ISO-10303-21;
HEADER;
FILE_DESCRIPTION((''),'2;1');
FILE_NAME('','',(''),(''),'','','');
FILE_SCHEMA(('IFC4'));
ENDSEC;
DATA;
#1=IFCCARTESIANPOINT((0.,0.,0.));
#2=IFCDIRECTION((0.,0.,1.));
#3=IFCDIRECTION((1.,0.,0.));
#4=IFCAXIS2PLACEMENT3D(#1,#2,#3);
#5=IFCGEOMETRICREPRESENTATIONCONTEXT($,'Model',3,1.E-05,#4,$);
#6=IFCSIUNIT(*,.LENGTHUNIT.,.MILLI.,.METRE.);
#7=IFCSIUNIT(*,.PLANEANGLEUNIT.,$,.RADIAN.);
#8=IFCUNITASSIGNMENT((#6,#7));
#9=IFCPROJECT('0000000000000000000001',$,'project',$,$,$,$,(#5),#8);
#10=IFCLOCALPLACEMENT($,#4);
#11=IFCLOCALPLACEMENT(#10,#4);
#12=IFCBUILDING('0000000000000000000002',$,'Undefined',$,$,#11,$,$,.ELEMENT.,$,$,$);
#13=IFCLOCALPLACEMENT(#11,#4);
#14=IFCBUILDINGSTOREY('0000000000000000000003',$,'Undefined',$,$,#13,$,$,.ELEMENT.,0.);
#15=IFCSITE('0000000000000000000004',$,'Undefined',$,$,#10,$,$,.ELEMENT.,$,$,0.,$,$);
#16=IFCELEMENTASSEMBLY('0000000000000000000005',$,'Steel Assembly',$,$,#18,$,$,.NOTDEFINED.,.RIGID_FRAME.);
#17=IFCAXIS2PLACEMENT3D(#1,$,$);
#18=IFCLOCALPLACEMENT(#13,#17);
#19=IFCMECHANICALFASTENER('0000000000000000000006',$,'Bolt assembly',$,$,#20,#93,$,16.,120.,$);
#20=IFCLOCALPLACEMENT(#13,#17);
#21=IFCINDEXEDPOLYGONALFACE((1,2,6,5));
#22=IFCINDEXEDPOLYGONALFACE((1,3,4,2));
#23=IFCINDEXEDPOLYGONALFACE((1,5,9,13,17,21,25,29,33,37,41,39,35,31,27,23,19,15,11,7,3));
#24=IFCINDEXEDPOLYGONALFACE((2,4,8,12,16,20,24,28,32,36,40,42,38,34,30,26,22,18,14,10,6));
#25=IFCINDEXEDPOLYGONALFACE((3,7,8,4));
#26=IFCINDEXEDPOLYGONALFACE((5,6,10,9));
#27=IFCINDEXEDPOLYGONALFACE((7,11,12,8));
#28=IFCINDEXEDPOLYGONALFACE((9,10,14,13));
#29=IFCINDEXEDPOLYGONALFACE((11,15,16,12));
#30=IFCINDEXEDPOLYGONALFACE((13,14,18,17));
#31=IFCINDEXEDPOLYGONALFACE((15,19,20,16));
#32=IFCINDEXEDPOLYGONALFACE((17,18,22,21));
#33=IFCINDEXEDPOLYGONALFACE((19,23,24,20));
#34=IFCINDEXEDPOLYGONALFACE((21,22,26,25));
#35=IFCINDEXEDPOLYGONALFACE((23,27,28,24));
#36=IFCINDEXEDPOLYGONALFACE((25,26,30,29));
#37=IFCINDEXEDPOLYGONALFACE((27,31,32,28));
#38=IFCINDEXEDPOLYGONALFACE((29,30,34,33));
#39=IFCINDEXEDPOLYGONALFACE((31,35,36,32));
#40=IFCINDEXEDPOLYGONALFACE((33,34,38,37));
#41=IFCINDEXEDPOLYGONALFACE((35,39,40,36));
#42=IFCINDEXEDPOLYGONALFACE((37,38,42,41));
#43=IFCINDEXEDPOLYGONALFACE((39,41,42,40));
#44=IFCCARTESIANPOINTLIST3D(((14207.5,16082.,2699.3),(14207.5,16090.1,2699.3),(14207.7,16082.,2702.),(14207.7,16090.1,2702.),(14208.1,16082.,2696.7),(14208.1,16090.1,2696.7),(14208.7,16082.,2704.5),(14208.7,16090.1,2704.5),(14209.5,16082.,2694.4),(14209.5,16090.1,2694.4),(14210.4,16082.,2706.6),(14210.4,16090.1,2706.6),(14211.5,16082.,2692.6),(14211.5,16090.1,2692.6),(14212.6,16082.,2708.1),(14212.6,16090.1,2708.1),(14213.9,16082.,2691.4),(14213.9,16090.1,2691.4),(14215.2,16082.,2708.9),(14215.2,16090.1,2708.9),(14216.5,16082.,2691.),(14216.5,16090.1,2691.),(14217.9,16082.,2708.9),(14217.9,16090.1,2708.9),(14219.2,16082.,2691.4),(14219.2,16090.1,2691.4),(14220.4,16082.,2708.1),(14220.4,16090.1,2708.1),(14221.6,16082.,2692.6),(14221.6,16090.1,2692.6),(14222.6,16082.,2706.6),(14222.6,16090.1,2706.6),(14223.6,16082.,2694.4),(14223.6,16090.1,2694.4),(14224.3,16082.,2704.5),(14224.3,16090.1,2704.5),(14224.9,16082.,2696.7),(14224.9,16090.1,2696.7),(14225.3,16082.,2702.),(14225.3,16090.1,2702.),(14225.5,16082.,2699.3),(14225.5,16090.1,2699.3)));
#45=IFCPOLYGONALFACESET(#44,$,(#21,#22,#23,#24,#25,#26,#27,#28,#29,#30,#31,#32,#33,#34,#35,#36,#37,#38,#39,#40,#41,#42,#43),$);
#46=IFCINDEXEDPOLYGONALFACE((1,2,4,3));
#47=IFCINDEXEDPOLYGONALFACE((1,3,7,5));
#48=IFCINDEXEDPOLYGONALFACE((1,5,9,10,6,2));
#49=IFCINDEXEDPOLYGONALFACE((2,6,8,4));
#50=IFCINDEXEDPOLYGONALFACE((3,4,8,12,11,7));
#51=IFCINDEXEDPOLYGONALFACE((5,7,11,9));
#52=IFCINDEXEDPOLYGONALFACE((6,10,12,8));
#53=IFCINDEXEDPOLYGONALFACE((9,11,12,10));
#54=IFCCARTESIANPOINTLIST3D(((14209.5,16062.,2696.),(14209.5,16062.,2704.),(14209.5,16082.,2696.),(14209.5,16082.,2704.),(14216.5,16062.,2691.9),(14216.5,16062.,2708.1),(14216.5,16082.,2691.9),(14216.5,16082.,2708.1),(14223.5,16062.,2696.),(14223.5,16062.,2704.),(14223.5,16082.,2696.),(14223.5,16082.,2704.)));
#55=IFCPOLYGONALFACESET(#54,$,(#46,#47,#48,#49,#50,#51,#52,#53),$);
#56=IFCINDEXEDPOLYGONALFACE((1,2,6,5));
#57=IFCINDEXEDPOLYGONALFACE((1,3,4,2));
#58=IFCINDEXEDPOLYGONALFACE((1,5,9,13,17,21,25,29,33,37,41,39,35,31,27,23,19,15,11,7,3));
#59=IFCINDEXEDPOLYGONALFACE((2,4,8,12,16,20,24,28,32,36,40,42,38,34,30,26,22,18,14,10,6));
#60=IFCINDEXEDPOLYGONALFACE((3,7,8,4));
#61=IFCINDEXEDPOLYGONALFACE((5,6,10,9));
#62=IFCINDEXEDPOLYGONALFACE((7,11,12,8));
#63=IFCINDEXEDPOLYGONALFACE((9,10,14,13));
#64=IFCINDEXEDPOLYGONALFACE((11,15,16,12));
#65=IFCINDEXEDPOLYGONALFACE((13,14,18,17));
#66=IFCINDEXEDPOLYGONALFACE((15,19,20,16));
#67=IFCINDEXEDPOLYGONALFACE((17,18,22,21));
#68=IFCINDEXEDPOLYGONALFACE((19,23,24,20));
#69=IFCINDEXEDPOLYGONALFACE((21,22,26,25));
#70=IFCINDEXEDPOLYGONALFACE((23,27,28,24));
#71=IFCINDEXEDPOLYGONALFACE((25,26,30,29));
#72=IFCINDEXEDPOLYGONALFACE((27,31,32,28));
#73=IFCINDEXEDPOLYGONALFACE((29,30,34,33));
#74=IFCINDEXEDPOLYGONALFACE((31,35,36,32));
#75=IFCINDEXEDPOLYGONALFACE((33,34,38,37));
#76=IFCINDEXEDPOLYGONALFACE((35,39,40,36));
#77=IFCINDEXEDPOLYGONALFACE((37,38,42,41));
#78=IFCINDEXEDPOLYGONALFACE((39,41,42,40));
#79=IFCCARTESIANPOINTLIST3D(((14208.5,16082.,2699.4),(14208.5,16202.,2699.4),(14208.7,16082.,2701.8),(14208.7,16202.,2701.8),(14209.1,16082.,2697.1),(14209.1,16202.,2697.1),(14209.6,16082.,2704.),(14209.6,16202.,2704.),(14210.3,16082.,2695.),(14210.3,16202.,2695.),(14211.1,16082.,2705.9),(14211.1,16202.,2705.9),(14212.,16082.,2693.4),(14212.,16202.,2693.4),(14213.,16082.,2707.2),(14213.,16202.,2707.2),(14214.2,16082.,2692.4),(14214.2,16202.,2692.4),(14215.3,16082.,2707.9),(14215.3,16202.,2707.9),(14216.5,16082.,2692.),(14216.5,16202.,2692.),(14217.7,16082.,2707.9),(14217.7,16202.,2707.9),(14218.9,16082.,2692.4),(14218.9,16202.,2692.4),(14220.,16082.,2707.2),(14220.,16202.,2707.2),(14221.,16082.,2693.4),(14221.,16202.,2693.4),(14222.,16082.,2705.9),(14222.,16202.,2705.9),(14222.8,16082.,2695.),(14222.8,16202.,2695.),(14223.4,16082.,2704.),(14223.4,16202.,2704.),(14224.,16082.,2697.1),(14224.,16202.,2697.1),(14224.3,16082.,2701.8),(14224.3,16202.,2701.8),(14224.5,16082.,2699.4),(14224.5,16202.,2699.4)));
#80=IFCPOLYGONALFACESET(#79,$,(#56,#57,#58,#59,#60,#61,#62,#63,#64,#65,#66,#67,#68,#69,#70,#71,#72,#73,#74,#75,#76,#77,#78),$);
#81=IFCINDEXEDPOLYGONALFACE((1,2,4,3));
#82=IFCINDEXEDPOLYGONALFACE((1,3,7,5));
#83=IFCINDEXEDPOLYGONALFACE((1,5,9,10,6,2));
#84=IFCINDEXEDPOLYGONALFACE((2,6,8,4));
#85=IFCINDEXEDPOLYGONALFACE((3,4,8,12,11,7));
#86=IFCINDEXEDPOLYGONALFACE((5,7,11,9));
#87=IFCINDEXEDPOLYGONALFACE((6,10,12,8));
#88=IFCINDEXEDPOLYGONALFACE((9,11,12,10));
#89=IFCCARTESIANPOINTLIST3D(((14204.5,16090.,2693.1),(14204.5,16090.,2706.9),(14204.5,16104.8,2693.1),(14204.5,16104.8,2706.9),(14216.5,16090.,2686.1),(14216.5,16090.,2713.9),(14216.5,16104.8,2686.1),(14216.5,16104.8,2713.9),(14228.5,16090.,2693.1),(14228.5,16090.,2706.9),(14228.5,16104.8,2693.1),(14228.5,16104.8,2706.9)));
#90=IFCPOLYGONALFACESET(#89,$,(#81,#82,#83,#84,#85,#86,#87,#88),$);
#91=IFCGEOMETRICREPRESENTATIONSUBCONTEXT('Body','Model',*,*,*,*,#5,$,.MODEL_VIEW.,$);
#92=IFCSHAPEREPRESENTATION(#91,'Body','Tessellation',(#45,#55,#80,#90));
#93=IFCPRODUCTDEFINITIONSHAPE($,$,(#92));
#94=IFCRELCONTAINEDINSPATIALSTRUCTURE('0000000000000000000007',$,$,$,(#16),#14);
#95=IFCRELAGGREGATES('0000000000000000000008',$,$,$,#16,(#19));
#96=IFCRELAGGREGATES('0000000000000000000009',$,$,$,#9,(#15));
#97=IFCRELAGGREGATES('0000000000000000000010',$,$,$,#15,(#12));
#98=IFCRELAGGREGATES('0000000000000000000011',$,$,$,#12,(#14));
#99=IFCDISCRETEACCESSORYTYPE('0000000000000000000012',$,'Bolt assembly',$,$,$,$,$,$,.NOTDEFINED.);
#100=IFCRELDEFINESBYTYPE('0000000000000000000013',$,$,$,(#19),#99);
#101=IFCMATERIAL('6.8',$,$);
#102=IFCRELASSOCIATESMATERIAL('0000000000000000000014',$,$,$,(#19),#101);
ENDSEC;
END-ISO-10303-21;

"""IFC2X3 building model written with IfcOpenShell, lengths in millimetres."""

from ifc_helpers import new_model, si_unit, frame, origin_with_axes, origin_2d_with_axis, place, context, subcontext, project, spatial, polyline, circle, outline, extrude, source, transform, mapped, material, type_object, element, aggregate, save


model = new_model("IFC2X3")

# Units and contexts
model_context = context("Model", 3, precision=1e-05, world=origin_with_axes())
body_context = subcontext(model_context, "Body", "Model", "MODEL_VIEW")
ifc_project = project(units=[si_unit("LENGTHUNIT", "METRE", prefix="MILLI"), si_unit("PLANEANGLEUNIT", "RADIAN")], contexts=[model_context])

# Site, building, storey
site_placement = place(None, origin_with_axes())
site = spatial("IfcSite", under=ifc_project, at=site_placement, Name="Undefined", CompositionType="ELEMENT", RefElevation=0.0)
building_placement = place(site_placement, origin_with_axes())
building = spatial("IfcBuilding", under=site, at=building_placement, Name="Undefined", CompositionType="ELEMENT")
storey_placement = place(building_placement, origin_with_axes())
storey = spatial("IfcBuildingStorey", under=building, at=storey_placement, Name="Undefined", CompositionType="ELEMENT", Elevation=0.0)

# Shared definitions
ifc_material_1 = material(Name="6.8")
discrete_accessory_type_1 = type_object("IfcDiscreteAccessoryType", Name="Bolt assembly")
shared_shape_1 = source(origin_with_axes(), body_context, "Body", "SweptSolid", [
    extrude(circle(Radius=9.0, at=origin_2d_with_axis()), frame((0.0, -8.0, 0.0), z_axis=(0.0, 1.0, 0.0), x_axis=(1.0, 0.0, 0.0)), (0.0, 0.0, 1.0), 8.1),
    extrude(outline(polyline([(8.1, 0.0), (4.0, 7.0), (-4.0, 7.0), (-8.1, 0.0), (-4.0, -7.0), (4.0, -7.0), (8.1, 0.0)])), frame((0.0, -28.0, 0.0), z_axis=(0.0, 1.0, 0.0), x_axis=(1.0, 0.0, 0.0)), (0.0, 0.0, 1.0), 20.0),
    extrude(circle(Radius=8.0, at=origin_2d_with_axis()), frame((0.0, -8.0, 0.0), z_axis=(0.0, 1.0, 0.0), x_axis=(1.0, 0.0, 0.0)), (0.0, 0.0, 1.0), 120.0),
    extrude(outline(polyline([(13.9, 0.0), (6.9, 12.0), (-6.9, 12.0), (-13.9, 0.0), (-6.9, -12.0), (6.9, -12.0), (13.9, 0.0)])), frame((0.0, 0.0, 0.0), z_axis=(0.0, 1.0, 0.0), x_axis=(1.0, 0.0, 0.0)), (0.0, 0.0, 1.0), 14.8),
])

# Element assembly, mechanical fastener
assembly_1_placement = place(storey_placement, origin_with_axes())
assembly_1 = element("IfcElementAssembly", 1, at=assembly_1_placement, inside=storey, Name="Steel Assembly", AssemblyPlace="NOTDEFINED", PredefinedType="RIGID_FRAME")
mechanical_fastener_1_placement = place(assembly_1_placement, frame((14216.5, 16090.0, 2700.0), z_axis=(1.0, 0.0, 0.0), x_axis=(0.0, 0.0, -1.0)))
mechanical_fastener_1 = element("IfcMechanicalFastener", 2, at=mechanical_fastener_1_placement, type_object=discrete_accessory_type_1, material=ifc_material_1, Name="Bolt assembly", NominalDiameter=16.0, NominalLength=120.0, context=body_context, shape_type="MappedRepresentation", body=[
    mapped(shared_shape_1, transform((0.0, 0.0, 0.0))),
])

aggregate(assembly_1, [mechanical_fastener_1])

save(model, "model.ifc")
